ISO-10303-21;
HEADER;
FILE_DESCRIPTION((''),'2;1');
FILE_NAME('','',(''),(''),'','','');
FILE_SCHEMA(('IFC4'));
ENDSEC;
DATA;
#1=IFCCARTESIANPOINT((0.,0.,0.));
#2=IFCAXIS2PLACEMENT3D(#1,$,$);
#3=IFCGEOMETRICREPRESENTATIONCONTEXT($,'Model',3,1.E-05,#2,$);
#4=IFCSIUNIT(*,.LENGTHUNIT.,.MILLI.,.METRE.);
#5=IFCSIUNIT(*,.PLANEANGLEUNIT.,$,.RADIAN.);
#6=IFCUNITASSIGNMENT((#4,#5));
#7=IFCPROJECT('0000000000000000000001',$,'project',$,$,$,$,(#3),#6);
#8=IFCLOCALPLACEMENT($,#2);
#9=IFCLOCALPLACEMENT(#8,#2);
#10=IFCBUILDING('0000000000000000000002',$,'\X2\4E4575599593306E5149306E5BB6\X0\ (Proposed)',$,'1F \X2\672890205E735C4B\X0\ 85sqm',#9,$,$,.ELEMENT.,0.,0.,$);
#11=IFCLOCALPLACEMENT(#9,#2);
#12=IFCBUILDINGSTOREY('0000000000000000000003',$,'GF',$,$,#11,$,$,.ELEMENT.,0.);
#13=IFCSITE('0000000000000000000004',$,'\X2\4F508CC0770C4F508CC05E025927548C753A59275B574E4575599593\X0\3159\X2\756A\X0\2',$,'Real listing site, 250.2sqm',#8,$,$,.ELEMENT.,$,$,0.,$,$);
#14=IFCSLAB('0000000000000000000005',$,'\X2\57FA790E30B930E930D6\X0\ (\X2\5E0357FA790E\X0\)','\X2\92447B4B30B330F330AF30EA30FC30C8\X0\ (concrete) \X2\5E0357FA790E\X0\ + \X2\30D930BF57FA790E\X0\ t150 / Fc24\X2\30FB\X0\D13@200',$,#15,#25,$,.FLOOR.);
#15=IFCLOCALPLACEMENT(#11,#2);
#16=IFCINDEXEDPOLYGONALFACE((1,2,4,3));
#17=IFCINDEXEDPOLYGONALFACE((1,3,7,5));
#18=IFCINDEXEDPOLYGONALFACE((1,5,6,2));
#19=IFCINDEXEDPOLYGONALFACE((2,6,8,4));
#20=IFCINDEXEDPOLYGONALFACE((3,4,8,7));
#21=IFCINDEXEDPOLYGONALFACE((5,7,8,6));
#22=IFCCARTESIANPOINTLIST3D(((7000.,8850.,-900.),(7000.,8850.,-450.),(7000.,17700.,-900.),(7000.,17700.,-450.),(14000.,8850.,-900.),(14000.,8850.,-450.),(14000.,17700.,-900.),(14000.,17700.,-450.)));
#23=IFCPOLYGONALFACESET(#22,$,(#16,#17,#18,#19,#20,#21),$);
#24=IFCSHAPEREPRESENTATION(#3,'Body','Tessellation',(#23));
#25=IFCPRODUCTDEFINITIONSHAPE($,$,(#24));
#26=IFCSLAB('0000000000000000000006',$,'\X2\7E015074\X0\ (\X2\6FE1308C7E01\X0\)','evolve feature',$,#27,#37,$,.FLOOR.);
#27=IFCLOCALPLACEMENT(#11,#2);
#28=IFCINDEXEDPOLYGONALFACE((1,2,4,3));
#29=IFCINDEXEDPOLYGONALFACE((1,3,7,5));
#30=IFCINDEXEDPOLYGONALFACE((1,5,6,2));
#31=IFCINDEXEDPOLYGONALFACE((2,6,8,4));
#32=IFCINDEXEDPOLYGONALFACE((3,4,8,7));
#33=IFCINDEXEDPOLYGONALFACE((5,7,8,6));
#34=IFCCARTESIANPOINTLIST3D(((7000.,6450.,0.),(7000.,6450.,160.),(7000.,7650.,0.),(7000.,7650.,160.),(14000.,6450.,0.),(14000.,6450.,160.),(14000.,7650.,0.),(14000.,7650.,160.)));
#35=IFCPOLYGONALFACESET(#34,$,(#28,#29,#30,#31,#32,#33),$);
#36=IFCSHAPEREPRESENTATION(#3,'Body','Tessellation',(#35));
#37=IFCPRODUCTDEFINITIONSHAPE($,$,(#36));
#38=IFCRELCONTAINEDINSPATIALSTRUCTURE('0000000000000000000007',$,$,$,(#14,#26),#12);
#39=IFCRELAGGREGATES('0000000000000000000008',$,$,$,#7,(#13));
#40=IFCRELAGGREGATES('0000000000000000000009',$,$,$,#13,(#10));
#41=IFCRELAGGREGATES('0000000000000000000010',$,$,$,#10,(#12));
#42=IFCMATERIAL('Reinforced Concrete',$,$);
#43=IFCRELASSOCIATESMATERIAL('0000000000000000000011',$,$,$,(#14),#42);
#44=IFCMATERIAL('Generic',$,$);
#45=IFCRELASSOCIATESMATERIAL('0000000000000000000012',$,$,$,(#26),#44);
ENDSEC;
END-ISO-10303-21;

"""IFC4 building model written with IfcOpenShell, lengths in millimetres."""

from ifc_helpers import new_model, si_unit, frame, frame_2d, origin, place, context, project, spatial, rectangle, extrude, material, element, save


model = new_model("IFC4")

# Units and contexts
model_context = context("Model", 3, precision=1e-05, world=origin())
ifc_project = project(units=[si_unit("LENGTHUNIT", "METRE", prefix="MILLI"), si_unit("PLANEANGLEUNIT", "RADIAN")], contexts=[model_context])

# Site, building, storey
site_placement = place(None, origin())
site = spatial("IfcSite", under=ifc_project, at=site_placement, Name="佐賀県佐賀市大和町大字久留間3159番2", ObjectType="Real listing site, 250.2sqm", CompositionType="ELEMENT", RefElevation=0.0)
building_placement = place(site_placement, origin())
building = spatial("IfcBuilding", under=site, at=building_placement, Name="久留間の光の家 (Proposed)", ObjectType="1F 木造平屋 85sqm", CompositionType="ELEMENT", ElevationOfRefHeight=0.0, ElevationOfTerrain=0.0)
storey_placement = place(building_placement, origin())
storey = spatial("IfcBuildingStorey", under=building, at=storey_placement, Name="GF", CompositionType="ELEMENT", Elevation=0.0)

# Slabs
ifc_material_1 = material(Name="Reinforced Concrete")
slab_1_placement = place(storey_placement, frame((3500.0, 4425.0, -450.0)))
element("IfcSlab", 1, at=slab_1_placement, inside=storey, material=ifc_material_1, Name="基礎スラブ (布基礎)", Description="鉄筋コンクリート (concrete) 布基礎 + ベタ基礎 t150 / Fc24・D13@200", PredefinedType="FLOOR", context=model_context, shape_type="SweptSolid", body=[
    extrude(rectangle(XDim=7000.0, YDim=8850.0, at=frame_2d((3500.0, 4425.0))), frame((3500.0, 4425.0, -450.0)), (0.0, 0.0, 1.0), 450.0),
])
ifc_material_2 = material(Name="Generic")
slab_2_placement = place(storey_placement, frame((3500.0, 3225.0, 0.0)))
element("IfcSlab", 2, at=slab_2_placement, inside=storey, material=ifc_material_2, Name="縁側 (濡れ縁)", Description="evolve feature", PredefinedType="FLOOR", context=model_context, shape_type="SweptSolid", body=[
    extrude(rectangle(XDim=7000.0, YDim=1200.0, at=frame_2d((3500.0, 600.0))), frame((3500.0, 3225.0, 0.0)), (0.0, 0.0, 1.0), 160.0),
])

save(model, "model.ifc")
